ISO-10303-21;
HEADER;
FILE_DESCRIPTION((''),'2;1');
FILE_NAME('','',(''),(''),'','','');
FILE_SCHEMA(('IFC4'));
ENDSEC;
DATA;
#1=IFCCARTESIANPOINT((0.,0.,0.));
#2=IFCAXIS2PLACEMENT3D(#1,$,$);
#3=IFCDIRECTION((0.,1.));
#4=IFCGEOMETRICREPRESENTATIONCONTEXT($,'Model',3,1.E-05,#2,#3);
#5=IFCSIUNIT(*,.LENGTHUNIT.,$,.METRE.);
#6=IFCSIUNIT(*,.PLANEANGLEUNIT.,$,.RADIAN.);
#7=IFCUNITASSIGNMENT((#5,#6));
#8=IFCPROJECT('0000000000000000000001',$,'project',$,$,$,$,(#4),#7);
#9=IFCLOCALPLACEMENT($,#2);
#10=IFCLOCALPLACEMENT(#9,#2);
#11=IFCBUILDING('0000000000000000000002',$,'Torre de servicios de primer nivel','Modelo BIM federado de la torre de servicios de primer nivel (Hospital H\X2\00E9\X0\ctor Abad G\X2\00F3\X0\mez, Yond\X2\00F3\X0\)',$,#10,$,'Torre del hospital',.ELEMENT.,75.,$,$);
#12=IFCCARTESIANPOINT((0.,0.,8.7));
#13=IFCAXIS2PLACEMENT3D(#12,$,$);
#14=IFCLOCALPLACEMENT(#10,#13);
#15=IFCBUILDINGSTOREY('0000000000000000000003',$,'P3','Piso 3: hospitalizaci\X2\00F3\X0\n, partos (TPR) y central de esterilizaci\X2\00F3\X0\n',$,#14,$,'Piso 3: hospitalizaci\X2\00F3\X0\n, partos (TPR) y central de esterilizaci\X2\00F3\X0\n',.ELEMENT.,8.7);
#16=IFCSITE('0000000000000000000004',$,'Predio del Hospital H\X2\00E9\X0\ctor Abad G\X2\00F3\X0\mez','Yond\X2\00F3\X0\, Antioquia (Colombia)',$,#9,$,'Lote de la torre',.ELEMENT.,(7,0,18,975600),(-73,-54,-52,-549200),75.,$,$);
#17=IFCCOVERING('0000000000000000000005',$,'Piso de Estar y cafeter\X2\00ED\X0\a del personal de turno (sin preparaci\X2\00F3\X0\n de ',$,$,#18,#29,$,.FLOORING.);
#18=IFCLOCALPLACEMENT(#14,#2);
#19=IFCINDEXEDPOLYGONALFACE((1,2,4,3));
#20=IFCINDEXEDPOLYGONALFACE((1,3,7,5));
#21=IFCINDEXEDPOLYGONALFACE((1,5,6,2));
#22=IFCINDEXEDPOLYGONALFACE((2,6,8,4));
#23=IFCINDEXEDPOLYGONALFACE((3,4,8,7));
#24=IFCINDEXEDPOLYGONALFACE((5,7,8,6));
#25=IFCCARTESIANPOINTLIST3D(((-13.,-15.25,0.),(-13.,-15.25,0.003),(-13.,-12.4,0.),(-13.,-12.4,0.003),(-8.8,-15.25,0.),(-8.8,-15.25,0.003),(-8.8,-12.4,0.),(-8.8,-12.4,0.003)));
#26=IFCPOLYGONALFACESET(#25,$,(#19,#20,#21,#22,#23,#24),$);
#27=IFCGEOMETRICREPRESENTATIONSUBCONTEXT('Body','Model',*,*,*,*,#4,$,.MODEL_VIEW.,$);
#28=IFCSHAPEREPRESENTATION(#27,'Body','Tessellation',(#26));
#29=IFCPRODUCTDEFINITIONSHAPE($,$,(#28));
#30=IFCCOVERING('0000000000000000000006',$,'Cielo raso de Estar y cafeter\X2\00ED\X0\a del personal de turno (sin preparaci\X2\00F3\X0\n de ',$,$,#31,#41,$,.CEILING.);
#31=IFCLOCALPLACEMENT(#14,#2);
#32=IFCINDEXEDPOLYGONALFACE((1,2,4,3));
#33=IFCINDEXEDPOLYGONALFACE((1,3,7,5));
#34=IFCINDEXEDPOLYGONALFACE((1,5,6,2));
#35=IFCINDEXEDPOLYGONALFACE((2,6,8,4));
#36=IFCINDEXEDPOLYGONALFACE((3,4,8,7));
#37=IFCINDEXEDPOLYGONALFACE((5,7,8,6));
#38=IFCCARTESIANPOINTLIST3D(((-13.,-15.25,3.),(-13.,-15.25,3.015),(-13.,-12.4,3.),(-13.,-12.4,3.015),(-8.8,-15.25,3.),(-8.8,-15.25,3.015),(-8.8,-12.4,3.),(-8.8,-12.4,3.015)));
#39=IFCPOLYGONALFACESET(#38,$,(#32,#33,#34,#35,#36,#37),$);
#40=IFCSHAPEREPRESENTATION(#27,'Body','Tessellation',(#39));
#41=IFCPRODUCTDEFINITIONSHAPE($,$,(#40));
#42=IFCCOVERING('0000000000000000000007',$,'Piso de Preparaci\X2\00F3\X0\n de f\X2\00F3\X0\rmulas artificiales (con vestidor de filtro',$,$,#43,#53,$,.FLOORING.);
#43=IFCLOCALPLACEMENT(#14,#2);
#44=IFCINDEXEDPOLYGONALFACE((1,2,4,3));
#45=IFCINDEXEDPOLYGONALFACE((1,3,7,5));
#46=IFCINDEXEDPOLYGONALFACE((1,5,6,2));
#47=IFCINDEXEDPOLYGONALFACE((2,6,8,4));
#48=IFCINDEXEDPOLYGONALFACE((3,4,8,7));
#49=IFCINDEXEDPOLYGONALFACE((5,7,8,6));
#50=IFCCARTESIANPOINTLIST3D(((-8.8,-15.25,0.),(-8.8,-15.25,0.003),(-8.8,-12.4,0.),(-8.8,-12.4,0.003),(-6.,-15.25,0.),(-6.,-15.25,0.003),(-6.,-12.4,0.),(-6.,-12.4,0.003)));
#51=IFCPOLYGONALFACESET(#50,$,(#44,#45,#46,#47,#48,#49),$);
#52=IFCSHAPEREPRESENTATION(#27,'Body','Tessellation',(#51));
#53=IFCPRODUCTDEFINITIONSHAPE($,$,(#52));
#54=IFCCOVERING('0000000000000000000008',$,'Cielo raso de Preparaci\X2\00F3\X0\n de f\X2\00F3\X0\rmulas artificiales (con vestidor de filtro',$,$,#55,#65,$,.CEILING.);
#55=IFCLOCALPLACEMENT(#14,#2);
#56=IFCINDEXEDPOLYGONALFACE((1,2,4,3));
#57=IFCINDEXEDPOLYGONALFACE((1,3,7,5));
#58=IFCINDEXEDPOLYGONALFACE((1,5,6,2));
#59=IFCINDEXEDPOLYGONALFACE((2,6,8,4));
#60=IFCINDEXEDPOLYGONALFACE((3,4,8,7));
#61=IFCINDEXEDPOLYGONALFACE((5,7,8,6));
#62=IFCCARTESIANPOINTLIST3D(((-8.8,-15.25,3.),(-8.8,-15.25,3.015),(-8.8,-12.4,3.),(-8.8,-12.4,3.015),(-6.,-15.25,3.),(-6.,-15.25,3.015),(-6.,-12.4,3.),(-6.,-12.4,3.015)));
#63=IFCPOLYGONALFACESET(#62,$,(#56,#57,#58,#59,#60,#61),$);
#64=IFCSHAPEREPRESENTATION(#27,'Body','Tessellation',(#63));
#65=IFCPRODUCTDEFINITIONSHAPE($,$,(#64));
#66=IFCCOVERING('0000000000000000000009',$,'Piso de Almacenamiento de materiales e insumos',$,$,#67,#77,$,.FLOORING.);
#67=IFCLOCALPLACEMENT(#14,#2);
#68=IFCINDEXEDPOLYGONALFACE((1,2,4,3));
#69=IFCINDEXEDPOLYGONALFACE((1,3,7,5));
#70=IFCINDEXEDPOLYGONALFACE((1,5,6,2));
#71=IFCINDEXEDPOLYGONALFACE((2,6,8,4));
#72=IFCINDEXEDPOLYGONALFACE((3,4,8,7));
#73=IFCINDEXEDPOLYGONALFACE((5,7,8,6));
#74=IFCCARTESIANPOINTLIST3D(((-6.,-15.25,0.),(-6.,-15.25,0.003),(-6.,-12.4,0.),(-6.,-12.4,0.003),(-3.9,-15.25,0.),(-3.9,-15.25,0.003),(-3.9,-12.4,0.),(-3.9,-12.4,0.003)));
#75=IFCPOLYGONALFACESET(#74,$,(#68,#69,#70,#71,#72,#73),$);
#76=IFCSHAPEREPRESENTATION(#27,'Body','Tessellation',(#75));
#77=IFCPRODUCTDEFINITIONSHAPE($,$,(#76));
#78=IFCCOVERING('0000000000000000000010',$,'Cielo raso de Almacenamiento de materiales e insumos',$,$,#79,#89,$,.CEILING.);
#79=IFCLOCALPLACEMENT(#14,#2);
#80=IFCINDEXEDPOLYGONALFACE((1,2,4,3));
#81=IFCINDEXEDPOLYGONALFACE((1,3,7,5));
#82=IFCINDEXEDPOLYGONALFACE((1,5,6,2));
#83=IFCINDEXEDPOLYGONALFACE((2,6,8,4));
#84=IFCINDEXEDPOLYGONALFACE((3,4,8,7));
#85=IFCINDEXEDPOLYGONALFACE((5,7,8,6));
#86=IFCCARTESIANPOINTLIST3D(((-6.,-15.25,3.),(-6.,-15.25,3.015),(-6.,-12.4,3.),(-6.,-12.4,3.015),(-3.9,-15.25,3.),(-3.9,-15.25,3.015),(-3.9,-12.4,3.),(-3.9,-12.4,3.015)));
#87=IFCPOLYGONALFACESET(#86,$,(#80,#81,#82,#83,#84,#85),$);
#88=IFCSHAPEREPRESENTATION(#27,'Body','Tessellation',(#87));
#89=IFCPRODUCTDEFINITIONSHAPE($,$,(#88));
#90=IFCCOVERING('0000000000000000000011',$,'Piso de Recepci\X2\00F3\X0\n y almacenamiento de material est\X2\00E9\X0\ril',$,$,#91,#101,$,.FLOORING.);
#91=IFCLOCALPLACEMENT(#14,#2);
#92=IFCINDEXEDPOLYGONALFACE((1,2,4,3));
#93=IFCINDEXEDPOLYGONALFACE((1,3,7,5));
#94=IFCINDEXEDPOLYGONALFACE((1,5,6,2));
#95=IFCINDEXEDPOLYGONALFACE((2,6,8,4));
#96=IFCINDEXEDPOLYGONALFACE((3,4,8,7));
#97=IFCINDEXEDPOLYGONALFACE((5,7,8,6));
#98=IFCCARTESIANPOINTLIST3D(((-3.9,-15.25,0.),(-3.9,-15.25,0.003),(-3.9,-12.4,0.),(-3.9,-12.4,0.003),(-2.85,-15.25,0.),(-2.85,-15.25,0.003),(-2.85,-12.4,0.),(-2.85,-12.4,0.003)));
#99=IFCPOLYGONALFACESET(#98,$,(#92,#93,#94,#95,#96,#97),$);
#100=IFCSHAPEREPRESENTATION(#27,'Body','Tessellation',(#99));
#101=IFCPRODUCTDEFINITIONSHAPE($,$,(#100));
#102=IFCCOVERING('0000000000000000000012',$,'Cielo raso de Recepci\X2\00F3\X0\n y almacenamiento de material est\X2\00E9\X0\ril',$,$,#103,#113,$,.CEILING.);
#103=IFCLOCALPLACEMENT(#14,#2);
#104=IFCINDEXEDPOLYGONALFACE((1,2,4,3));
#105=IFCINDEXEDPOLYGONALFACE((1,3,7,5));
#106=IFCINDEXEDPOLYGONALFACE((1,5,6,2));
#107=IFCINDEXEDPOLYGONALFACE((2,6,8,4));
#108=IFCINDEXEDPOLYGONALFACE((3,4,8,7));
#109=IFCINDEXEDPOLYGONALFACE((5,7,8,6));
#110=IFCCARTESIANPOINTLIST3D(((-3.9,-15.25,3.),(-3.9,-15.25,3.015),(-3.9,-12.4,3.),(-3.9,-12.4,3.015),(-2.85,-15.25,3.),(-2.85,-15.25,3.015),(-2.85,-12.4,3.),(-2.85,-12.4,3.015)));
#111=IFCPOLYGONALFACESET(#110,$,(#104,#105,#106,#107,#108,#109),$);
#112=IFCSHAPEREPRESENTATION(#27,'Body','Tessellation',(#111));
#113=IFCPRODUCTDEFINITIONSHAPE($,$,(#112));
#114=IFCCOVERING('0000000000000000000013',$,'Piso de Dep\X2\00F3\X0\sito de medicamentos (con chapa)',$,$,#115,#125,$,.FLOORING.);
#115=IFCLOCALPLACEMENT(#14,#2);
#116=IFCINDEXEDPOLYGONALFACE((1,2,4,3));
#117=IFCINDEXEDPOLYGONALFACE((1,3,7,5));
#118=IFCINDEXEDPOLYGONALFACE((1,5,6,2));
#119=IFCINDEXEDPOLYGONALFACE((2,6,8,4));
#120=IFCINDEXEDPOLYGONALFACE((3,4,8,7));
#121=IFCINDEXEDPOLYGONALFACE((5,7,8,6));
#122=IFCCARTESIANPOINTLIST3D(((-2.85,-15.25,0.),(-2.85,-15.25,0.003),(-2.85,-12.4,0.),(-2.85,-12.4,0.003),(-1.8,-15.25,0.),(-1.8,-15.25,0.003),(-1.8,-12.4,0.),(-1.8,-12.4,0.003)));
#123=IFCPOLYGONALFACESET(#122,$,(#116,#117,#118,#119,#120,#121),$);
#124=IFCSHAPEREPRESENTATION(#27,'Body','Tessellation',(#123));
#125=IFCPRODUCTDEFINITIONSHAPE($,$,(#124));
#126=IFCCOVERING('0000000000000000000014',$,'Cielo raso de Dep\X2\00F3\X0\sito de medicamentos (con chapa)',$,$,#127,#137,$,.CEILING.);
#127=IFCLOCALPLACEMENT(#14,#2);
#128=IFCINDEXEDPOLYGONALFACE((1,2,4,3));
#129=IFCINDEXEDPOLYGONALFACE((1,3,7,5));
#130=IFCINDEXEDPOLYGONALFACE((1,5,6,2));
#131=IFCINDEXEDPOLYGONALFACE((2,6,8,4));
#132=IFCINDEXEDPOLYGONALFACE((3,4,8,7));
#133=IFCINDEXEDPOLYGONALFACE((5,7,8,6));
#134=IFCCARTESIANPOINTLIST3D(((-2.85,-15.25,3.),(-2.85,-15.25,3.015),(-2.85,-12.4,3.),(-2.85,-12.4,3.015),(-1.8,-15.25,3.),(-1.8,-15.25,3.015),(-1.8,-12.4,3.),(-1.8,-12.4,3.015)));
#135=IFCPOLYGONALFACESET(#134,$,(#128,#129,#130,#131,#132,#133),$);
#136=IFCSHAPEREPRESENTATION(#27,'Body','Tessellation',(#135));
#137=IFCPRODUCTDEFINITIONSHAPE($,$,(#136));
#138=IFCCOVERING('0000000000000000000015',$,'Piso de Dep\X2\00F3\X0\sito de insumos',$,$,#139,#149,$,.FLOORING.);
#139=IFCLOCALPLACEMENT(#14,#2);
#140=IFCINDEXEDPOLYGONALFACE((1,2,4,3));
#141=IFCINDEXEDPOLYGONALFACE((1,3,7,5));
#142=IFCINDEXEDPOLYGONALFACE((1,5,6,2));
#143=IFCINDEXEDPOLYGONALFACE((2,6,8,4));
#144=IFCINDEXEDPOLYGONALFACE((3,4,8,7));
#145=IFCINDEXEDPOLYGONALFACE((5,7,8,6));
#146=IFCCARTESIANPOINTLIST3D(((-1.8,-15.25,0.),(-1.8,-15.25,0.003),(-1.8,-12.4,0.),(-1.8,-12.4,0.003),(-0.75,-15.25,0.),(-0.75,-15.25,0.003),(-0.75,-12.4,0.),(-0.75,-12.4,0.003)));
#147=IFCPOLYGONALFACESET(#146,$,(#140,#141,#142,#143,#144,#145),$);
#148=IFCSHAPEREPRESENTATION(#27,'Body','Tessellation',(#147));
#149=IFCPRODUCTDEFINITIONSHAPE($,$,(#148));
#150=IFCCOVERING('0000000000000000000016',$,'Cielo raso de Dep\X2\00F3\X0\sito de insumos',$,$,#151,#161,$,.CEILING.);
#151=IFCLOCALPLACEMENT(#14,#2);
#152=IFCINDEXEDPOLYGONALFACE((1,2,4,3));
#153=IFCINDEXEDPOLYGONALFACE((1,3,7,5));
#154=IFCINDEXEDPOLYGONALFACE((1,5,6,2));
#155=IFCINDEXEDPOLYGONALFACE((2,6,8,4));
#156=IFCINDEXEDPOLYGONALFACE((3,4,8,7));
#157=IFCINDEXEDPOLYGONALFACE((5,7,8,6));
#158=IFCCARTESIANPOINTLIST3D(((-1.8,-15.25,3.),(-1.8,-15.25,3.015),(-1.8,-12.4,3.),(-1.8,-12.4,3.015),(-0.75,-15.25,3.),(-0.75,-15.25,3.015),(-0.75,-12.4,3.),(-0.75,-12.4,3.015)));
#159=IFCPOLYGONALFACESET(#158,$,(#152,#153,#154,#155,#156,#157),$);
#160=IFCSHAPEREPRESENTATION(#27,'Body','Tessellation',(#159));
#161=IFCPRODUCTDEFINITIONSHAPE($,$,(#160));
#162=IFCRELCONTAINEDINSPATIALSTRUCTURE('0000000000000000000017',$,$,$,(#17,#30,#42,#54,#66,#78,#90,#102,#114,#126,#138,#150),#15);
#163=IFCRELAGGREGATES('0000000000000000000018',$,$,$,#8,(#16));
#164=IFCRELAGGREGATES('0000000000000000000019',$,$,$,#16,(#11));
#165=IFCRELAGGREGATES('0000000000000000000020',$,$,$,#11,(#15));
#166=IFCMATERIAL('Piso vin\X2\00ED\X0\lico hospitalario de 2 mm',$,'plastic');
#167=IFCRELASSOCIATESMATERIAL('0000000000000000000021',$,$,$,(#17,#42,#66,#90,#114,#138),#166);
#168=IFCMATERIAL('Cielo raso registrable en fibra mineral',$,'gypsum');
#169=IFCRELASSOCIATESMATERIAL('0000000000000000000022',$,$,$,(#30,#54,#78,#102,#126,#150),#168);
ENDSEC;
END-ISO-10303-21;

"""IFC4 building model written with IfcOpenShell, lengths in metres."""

from ifc_helpers import new_model, si_unit, direction, frame, origin, place, context, subcontext, project, spatial, indexed_curve, outline, extrude, material, element, save


model = new_model("IFC4")

# Units and contexts
model_context = context("Model", 3, precision=1e-05, world=origin(), true_north=direction((0.0, 1.0)))
body_context = subcontext(model_context, "Body", "Model", "MODEL_VIEW")
ifc_project = project(units=[si_unit("LENGTHUNIT", "METRE"), si_unit("PLANEANGLEUNIT", "RADIAN")], contexts=[model_context])

# Site, building, storey
site_placement = place(None, origin())
site = spatial("IfcSite", under=ifc_project, at=site_placement, Name="Predio del Hospital Héctor Abad Gómez", Description="Yondó, Antioquia (Colombia)", LongName="Lote de la torre", CompositionType="ELEMENT", RefLatitude=(7, 0, 18, 975600), RefLongitude=(-73, -54, -52, -549200), RefElevation=75.0)
building_placement = place(site_placement, origin())
building = spatial("IfcBuilding", under=site, at=building_placement, Name="Torre de servicios de primer nivel", Description="Modelo BIM federado de la torre de servicios de primer nivel (Hospital Héctor Abad Gómez, Yondó)", LongName="Torre del hospital", CompositionType="ELEMENT", ElevationOfRefHeight=75.0)
placement = place(building_placement, frame((0.0, 0.0, 8.7)))
storey = spatial("IfcBuildingStorey", under=building, at=placement, Name="P3", Description="Piso 3: hospitalización, partos (TPR) y central de esterilización", LongName="Piso 3: hospitalización, partos (TPR) y central de esterilización", CompositionType="ELEMENT", Elevation=8.7)

# Coverings
ifc_material_1 = material(Name="Piso vinílico hospitalario de 2 mm", Category="plastic")
ifc_material_2 = material(Name="Cielo raso registrable en fibra mineral", Category="gypsum")
element("IfcCovering", 1, at=placement, inside=storey, material=ifc_material_1, Name="Piso de Estar y cafetería del personal de turno (sin preparación de ", PredefinedType="FLOORING", context=body_context, shape_type="SweptSolid", body=[
    extrude(outline(indexed_curve([(-13.0, -15.25), (-8.8, -15.25), (-8.8, -12.4), (-13.0, -12.4), (-13.0, -15.25)], self_intersect=False)), origin(), (0.0, 0.0, 1.0), 0.003),
])
element("IfcCovering", 2, at=placement, inside=storey, material=ifc_material_2, Name="Cielo raso de Estar y cafetería del personal de turno (sin preparación de ", PredefinedType="CEILING", context=body_context, shape_type="SweptSolid", body=[
    extrude(outline(indexed_curve([(-13.0, -15.25), (-8.8, -15.25), (-8.8, -12.4), (-13.0, -12.4), (-13.0, -15.25)], self_intersect=False)), frame((0.0, 0.0, 3.0)), (0.0, 0.0, 1.0), 0.015),
])
element("IfcCovering", 3, at=placement, inside=storey, material=ifc_material_1, Name="Piso de Preparación de fórmulas artificiales (con vestidor de filtro", PredefinedType="FLOORING", context=body_context, shape_type="SweptSolid", body=[
    extrude(outline(indexed_curve([(-8.8, -15.25), (-6.0, -15.25), (-6.0, -12.4), (-8.8, -12.4), (-8.8, -15.25)], self_intersect=False)), origin(), (0.0, 0.0, 1.0), 0.003),
])
element("IfcCovering", 4, at=placement, inside=storey, material=ifc_material_2, Name="Cielo raso de Preparación de fórmulas artificiales (con vestidor de filtro", PredefinedType="CEILING", context=body_context, shape_type="SweptSolid", body=[
    extrude(outline(indexed_curve([(-8.8, -15.25), (-6.0, -15.25), (-6.0, -12.4), (-8.8, -12.4), (-8.8, -15.25)], self_intersect=False)), frame((0.0, 0.0, 3.0)), (0.0, 0.0, 1.0), 0.015),
])
element("IfcCovering", 5, at=placement, inside=storey, material=ifc_material_1, Name="Piso de Almacenamiento de materiales e insumos", PredefinedType="FLOORING", context=body_context, shape_type="SweptSolid", body=[
    extrude(outline(indexed_curve([(-6.0, -15.25), (-3.9, -15.25), (-3.9, -12.4), (-6.0, -12.4), (-6.0, -15.25)], self_intersect=False)), origin(), (0.0, 0.0, 1.0), 0.003),
])
element("IfcCovering", 6, at=placement, inside=storey, material=ifc_material_2, Name="Cielo raso de Almacenamiento de materiales e insumos", PredefinedType="CEILING", context=body_context, shape_type="SweptSolid", body=[
    extrude(outline(indexed_curve([(-6.0, -15.25), (-3.9, -15.25), (-3.9, -12.4), (-6.0, -12.4), (-6.0, -15.25)], self_intersect=False)), frame((0.0, 0.0, 3.0)), (0.0, 0.0, 1.0), 0.015),
])
element("IfcCovering", 7, at=placement, inside=storey, material=ifc_material_1, Name="Piso de Recepción y almacenamiento de material estéril", PredefinedType="FLOORING", context=body_context, shape_type="SweptSolid", body=[
    extrude(outline(indexed_curve([(-3.9, -15.25), (-2.85, -15.25), (-2.85, -12.4), (-3.9, -12.4), (-3.9, -15.25)], self_intersect=False)), origin(), (0.0, 0.0, 1.0), 0.003),
])
element("IfcCovering", 8, at=placement, inside=storey, material=ifc_material_2, Name="Cielo raso de Recepción y almacenamiento de material estéril", PredefinedType="CEILING", context=body_context, shape_type="SweptSolid", body=[
    extrude(outline(indexed_curve([(-3.9, -15.25), (-2.85, -15.25), (-2.85, -12.4), (-3.9, -12.4), (-3.9, -15.25)], self_intersect=False)), frame((0.0, 0.0, 3.0)), (0.0, 0.0, 1.0), 0.015),
])
element("IfcCovering", 9, at=placement, inside=storey, material=ifc_material_1, Name="Piso de Depósito de medicamentos (con chapa)", PredefinedType="FLOORING", context=body_context, shape_type="SweptSolid", body=[
    extrude(outline(indexed_curve([(-2.85, -15.25), (-1.8, -15.25), (-1.8, -12.4), (-2.85, -12.4), (-2.85, -15.25)], self_intersect=False)), origin(), (0.0, 0.0, 1.0), 0.003),
])
element("IfcCovering", 10, at=placement, inside=storey, material=ifc_material_2, Name="Cielo raso de Depósito de medicamentos (con chapa)", PredefinedType="CEILING", context=body_context, shape_type="SweptSolid", body=[
    extrude(outline(indexed_curve([(-2.85, -15.25), (-1.8, -15.25), (-1.8, -12.4), (-2.85, -12.4), (-2.85, -15.25)], self_intersect=False)), frame((0.0, 0.0, 3.0)), (0.0, 0.0, 1.0), 0.015),
])
element("IfcCovering", 11, at=placement, inside=storey, material=ifc_material_1, Name="Piso de Depósito de insumos", PredefinedType="FLOORING", context=body_context, shape_type="SweptSolid", body=[
    extrude(outline(indexed_curve([(-1.8, -15.25), (-0.75, -15.25), (-0.75, -12.4), (-1.8, -12.4), (-1.8, -15.25)], self_intersect=False)), origin(), (0.0, 0.0, 1.0), 0.003),
])
element("IfcCovering", 12, at=placement, inside=storey, material=ifc_material_2, Name="Cielo raso de Depósito de insumos", PredefinedType="CEILING", context=body_context, shape_type="SweptSolid", body=[
    extrude(outline(indexed_curve([(-1.8, -15.25), (-0.75, -15.25), (-0.75, -12.4), (-1.8, -12.4), (-1.8, -15.25)], self_intersect=False)), frame((0.0, 0.0, 3.0)), (0.0, 0.0, 1.0), 0.015),
])

save(model, "model.ifc")
